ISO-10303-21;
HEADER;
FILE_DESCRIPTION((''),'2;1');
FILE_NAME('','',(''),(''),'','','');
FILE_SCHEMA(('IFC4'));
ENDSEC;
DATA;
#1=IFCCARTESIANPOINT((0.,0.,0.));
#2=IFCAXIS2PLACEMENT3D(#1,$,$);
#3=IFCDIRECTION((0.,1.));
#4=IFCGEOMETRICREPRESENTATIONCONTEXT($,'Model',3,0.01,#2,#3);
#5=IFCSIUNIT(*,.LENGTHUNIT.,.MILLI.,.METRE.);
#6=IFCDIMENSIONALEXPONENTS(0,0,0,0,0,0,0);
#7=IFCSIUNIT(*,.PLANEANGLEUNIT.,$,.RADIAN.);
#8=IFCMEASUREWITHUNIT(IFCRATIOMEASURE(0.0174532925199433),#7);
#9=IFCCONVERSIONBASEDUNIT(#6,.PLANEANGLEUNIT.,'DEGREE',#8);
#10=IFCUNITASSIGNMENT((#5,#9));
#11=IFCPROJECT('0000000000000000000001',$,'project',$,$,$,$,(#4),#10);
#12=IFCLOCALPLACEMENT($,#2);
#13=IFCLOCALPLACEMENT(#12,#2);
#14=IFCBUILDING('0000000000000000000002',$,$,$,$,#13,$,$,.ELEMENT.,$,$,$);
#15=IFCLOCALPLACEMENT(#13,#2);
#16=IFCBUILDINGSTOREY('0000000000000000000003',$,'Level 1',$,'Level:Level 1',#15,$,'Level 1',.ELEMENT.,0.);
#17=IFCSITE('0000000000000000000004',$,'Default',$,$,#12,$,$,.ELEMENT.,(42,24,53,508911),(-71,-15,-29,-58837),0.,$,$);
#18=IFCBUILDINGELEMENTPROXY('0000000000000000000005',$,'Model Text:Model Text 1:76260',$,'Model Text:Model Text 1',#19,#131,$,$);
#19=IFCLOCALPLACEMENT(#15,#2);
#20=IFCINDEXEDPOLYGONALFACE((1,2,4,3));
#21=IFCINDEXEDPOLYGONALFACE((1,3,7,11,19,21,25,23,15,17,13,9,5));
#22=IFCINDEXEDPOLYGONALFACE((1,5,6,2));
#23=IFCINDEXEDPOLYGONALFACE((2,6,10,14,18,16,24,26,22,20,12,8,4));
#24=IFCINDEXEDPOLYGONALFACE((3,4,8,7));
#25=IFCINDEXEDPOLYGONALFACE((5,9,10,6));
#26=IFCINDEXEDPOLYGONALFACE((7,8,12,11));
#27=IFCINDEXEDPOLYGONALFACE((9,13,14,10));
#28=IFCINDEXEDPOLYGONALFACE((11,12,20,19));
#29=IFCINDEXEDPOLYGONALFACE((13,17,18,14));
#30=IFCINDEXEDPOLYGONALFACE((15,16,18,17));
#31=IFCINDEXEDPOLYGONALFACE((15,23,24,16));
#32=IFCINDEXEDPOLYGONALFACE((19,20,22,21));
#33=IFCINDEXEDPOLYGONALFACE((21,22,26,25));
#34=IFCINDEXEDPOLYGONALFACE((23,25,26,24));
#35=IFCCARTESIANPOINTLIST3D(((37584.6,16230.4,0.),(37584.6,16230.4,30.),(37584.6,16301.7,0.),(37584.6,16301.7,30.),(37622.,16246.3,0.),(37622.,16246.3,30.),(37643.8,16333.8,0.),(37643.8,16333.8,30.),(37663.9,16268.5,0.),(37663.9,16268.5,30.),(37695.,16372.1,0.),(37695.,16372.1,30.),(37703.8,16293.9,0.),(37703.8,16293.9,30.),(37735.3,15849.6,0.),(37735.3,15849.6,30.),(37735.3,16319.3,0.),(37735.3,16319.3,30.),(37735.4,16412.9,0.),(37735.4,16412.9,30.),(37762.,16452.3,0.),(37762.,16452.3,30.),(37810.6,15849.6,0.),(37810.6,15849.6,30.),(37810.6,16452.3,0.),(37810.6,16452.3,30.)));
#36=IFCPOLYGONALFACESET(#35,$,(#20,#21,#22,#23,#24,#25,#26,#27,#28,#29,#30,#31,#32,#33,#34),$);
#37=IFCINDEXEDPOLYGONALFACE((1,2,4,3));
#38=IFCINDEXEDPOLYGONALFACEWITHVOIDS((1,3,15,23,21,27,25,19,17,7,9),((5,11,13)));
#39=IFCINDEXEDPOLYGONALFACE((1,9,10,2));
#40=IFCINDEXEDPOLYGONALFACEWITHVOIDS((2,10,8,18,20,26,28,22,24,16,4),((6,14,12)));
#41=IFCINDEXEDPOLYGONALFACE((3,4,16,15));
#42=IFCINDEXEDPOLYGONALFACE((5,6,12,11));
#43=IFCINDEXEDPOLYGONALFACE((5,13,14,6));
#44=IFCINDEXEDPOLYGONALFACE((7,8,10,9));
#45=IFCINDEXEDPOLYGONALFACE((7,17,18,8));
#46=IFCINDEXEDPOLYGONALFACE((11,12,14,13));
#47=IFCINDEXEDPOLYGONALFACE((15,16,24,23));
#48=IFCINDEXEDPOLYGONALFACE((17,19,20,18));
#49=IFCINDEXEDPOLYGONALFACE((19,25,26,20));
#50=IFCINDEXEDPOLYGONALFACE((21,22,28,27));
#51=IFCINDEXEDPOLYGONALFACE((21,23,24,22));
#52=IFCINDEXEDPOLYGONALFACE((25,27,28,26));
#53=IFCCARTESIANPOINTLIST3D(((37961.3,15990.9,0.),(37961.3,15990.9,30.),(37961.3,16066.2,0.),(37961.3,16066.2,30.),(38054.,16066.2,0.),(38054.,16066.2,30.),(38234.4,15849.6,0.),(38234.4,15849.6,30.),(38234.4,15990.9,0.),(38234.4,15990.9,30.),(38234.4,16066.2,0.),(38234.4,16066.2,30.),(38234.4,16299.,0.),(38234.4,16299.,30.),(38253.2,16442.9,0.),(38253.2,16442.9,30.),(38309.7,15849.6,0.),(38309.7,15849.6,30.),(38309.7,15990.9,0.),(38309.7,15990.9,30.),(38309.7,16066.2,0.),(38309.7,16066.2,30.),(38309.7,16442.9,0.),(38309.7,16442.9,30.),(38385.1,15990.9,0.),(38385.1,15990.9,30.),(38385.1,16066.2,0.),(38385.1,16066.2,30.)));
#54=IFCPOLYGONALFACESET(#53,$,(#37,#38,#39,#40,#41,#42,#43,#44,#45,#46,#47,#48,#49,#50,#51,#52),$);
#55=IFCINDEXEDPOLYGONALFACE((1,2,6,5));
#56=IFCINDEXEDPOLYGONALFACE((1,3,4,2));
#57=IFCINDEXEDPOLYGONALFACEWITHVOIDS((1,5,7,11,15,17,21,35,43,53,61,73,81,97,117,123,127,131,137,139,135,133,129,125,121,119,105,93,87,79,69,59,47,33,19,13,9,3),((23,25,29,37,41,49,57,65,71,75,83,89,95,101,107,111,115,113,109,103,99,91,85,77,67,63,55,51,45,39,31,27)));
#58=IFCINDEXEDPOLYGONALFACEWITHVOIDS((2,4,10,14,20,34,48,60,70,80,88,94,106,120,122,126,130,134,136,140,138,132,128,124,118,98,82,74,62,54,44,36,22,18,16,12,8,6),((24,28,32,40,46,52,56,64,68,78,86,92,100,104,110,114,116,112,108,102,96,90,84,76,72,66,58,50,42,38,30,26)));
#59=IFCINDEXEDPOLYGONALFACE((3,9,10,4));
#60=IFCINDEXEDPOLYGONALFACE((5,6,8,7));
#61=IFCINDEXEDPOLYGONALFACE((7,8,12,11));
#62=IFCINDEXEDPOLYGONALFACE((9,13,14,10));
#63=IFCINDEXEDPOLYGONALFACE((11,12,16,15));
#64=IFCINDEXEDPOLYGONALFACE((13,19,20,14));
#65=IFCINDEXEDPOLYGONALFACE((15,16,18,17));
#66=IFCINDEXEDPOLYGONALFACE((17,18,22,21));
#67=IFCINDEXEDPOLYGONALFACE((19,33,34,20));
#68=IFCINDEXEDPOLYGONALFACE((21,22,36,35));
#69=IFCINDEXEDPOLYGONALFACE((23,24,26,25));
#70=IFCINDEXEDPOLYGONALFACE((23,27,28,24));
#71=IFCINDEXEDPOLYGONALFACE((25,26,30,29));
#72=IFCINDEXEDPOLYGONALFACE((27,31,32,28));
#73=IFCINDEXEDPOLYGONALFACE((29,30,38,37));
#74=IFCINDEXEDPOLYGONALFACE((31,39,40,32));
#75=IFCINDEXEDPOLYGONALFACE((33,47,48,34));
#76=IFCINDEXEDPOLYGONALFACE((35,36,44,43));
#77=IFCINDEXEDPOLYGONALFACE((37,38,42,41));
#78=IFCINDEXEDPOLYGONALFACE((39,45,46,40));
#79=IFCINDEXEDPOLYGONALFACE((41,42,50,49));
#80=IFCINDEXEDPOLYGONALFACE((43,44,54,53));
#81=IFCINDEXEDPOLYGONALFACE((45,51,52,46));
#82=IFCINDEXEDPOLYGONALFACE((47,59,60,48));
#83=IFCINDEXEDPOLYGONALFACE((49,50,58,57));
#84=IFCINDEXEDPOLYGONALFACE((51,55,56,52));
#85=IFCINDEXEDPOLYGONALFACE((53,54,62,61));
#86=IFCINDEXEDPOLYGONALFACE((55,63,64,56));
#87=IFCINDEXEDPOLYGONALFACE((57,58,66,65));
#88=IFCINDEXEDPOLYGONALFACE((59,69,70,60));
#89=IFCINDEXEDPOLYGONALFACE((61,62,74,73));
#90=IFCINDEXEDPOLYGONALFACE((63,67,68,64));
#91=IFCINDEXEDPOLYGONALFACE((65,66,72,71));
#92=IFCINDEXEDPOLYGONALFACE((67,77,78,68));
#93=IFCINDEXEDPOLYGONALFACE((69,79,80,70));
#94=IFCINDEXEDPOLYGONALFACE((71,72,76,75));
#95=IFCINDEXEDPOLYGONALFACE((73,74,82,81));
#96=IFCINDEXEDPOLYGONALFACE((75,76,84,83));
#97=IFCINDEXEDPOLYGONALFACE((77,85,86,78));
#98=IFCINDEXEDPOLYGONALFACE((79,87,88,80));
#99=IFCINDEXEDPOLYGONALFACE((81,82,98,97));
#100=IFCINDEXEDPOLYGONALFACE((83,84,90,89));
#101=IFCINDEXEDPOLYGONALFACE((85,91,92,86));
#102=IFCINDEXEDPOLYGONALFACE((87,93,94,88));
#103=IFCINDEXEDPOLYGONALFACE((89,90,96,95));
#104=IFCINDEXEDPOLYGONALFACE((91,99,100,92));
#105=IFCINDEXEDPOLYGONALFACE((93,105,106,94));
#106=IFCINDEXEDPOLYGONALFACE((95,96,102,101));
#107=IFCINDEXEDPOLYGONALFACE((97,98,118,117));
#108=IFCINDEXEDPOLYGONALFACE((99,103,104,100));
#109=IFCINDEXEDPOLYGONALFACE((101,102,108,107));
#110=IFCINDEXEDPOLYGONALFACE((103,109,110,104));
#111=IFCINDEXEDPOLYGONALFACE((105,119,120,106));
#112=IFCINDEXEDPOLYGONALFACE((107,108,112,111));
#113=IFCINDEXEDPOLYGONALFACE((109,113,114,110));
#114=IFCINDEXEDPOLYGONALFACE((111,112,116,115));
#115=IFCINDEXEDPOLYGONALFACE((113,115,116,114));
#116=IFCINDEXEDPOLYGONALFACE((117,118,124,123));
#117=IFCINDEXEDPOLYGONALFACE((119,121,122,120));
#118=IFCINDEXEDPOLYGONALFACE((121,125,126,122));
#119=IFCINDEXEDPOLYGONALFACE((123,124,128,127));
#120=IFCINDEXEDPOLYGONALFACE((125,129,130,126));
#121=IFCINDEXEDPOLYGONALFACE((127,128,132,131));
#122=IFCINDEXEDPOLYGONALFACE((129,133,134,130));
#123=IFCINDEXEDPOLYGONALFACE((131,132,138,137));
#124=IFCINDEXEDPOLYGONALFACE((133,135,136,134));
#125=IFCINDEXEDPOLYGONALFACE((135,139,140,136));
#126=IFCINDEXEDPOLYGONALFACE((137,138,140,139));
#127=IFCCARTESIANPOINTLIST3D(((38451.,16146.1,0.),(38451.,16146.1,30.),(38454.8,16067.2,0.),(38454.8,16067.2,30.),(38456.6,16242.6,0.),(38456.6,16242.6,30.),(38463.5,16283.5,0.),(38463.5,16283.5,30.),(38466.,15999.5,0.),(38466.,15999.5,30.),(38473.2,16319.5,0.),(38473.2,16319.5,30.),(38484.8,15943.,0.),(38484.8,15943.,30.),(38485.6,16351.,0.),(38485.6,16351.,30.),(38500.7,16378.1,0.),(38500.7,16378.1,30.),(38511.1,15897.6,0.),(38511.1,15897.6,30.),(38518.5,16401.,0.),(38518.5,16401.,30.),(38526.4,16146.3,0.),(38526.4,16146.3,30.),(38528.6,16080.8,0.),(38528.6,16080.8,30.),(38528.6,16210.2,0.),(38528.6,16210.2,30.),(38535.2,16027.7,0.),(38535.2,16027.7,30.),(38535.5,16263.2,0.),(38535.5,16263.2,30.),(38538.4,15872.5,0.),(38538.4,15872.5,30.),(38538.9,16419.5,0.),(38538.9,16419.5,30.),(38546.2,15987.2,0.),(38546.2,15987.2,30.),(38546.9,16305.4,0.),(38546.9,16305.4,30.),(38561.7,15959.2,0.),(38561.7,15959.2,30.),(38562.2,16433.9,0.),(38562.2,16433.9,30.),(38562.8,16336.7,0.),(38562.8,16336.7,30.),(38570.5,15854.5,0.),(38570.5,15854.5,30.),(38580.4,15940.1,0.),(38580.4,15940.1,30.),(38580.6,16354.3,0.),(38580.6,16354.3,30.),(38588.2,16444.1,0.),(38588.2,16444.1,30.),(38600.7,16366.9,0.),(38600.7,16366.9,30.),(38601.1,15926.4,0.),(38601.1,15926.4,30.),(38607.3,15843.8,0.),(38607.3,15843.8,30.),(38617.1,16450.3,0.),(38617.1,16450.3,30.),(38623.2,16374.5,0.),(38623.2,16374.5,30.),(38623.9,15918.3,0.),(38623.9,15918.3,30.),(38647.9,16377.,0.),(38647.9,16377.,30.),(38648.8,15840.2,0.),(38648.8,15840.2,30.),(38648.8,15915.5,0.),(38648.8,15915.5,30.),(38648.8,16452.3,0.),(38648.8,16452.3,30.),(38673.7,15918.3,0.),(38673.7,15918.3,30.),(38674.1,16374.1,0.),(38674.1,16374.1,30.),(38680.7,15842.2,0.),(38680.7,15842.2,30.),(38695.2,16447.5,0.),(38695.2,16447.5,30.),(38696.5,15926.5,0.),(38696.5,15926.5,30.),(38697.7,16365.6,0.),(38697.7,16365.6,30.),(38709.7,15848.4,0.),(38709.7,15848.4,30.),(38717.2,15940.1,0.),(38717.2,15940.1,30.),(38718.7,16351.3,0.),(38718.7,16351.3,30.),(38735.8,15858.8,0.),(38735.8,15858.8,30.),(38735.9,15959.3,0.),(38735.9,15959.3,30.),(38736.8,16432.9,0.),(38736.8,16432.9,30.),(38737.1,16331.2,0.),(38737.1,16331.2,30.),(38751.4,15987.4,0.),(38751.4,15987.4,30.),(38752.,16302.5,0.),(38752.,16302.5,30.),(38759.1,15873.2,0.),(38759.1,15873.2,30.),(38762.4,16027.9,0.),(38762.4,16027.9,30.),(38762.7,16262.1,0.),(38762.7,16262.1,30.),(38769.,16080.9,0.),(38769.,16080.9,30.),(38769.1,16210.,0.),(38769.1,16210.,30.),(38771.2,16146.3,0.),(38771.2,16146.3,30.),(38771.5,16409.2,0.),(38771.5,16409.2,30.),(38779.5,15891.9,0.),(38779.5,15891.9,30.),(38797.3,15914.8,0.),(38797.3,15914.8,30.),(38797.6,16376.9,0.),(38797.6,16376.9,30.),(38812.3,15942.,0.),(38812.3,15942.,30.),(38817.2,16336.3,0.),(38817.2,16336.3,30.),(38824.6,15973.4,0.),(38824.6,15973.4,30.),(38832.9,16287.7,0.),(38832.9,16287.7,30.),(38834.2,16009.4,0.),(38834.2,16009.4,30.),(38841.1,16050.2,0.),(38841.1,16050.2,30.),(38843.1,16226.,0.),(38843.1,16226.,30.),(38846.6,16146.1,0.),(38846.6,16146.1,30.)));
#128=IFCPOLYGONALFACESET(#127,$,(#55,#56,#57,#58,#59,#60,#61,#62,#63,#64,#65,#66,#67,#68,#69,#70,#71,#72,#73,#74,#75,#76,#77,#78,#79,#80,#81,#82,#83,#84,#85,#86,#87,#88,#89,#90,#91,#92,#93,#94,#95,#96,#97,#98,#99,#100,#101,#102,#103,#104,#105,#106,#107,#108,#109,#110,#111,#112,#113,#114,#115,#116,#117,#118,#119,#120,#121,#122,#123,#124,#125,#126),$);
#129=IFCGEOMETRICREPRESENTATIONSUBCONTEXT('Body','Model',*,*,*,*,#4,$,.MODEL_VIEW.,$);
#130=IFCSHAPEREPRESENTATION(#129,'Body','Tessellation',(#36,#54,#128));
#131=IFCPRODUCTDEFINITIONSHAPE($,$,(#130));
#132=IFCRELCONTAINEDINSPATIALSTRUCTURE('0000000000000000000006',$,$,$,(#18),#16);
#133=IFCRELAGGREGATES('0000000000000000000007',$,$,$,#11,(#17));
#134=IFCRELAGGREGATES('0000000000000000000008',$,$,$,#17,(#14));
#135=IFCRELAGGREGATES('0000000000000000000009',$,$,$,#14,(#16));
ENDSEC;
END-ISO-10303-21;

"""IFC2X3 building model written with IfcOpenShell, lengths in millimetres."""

from ifc_helpers import new_model, entity, si_unit, converted_unit, direction, frame, origin, place, context, subcontext, project, spatial, polyline, outline, extrude, element, save


model = new_model("IFC2X3")

# Units and contexts
model_context = context("Model", 3, precision=0.01, world=origin(), true_north=direction((0.0, 1.0)))
body_context = subcontext(model_context, "Body", "Model", "MODEL_VIEW")
ifc_project = project(units=[si_unit("LENGTHUNIT", "METRE", prefix="MILLI"), converted_unit("PLANEANGLEUNIT", "DEGREE", entity("IfcRatioMeasure", 0.0174532925199433), si_unit("PLANEANGLEUNIT", "RADIAN"), dimensions=[0, 0, 0, 0, 0, 0, 0])], contexts=[model_context])

# Site, building, storey
site_placement = place(None, origin())
site = spatial("IfcSite", under=ifc_project, at=site_placement, Name="Default", CompositionType="ELEMENT", RefLatitude=(42, 24, 53, 508911), RefLongitude=(-71, -15, -29, -58837), RefElevation=0.0)
building_placement = place(site_placement, origin())
building = spatial("IfcBuilding", under=site, at=building_placement, CompositionType="ELEMENT")
storey_placement = place(building_placement, origin())
storey = spatial("IfcBuildingStorey", under=building, at=storey_placement, Name="Level 1", ObjectType="Level:Level 1", LongName="Level 1", CompositionType="ELEMENT", Elevation=0.0)

# Building element proxy
proxy_1_placement = place(storey_placement, origin())
element("IfcBuildingElementProxy", 1, at=proxy_1_placement, inside=storey, Name="Model Text:Model Text 1:76260", ObjectType="Model Text:Model Text 1", context=body_context, shape_type="SweptSolid", body=[
    extrude(outline(polyline([(-410.6, -111.6), (192.1, -111.6), (192.1, -63.1), (152.7, -36.4), (111.9, 4.0), (73.6, 55.2), (41.4, 114.4), (-29.8, 114.4), (-13.9, 77.0), (8.3, 35.1), (33.7, -4.8), (59.1, -36.3), (-410.6, -36.3), (-410.6, -111.6)])), frame((37699.0, 16260.2, 0.0), z_axis=(0.0, 0.0, 1.0), x_axis=(0.0, 1.0, 0.0)), (0.0, 0.0, 1.0), 30.0),
    extrude(outline(polyline([(-6.8, -218.3), (68.5, -218.3), (68.5, -77.1), (143.8, -77.1), (143.8, -1.7), (68.5, -1.7), (68.5, 375.0), (12.0, 375.0), (-280.0, -1.7), (-280.0, -77.1), (-6.8, -77.1), (-6.8, -218.3)]), holes=[polyline([(-6.8, -1.7), (-187.3, -1.7), (-6.8, 231.1), (-6.8, -1.7)])]), frame((38241.3, 16067.9, 0.0)), (0.0, 0.0, 1.0), 30.0),
    extrude(outline(polyline([(-10.6, -198.7), (68.3, -198.7), (136.5, -190.7), (193.9, -174.7), (240.5, -150.6), (266.9, -124.4), (286.3, -93.2), (298.8, -57.0), (304.3, -15.7), (303.8, 16.2), (299.0, 45.5), (289.9, 72.1), (276.6, 96.0), (258.9, 117.3), (236.9, 136.2), (210.4, 152.5), (179.6, 166.3), (144.1, 177.6), (103.7, 186.3), (8.2, 196.4), (-71.8, 196.7), (-134.0, 189.4), (-183.3, 176.1), (-224.7, 158.4), (-258.2, 133.9), (-283.5, 100.3), (-300.1, 59.5), (-307.1, 13.4), (-306.6, -18.4), (-301.8, -47.5), (-292.8, -74.0), (-279.6, -97.9), (-262.0, -119.2), (-240.0, -138.1), (-213.6, -154.5), (-182.8, -168.4), (-147.3, -179.8), (-106.7, -188.6), (-10.6, -198.7)]), holes=[polyline([(-7.2, -123.5), (-71.0, -118.2), (-123.6, -108.8), (-165.2, -95.4), (-195.7, -78.0), (-212.4, -59.4), (-224.1, -38.7), (-230.6, -15.9), (-231.9, 8.9), (-227.8, 35.0), (-218.1, 58.1), (-202.8, 78.4), (-182.0, 95.8), (-152.6, 109.4), (-111.7, 118.1), (-59.4, 122.0), (4.4, 121.1), (69.6, 115.8), (122.2, 106.7), (162.2, 93.7), (189.5, 77.0), (207.7, 57.4), (220.4, 36.0), (227.5, 12.8), (229.1, -12.1), (225.2, -36.8), (215.9, -59.2), (201.3, -79.3), (181.4, -97.1), (152.6, -111.2), (111.6, -120.3), (58.3, -124.4), (-7.2, -123.5)])]), frame((38650.0, 16144.9, 0.0), z_axis=(0.0, 0.0, 1.0), x_axis=(0.047515, -0.998871, 0.0)), (0.0, 0.0, 1.0), 30.0),
])

save(model, "model.ifc")
